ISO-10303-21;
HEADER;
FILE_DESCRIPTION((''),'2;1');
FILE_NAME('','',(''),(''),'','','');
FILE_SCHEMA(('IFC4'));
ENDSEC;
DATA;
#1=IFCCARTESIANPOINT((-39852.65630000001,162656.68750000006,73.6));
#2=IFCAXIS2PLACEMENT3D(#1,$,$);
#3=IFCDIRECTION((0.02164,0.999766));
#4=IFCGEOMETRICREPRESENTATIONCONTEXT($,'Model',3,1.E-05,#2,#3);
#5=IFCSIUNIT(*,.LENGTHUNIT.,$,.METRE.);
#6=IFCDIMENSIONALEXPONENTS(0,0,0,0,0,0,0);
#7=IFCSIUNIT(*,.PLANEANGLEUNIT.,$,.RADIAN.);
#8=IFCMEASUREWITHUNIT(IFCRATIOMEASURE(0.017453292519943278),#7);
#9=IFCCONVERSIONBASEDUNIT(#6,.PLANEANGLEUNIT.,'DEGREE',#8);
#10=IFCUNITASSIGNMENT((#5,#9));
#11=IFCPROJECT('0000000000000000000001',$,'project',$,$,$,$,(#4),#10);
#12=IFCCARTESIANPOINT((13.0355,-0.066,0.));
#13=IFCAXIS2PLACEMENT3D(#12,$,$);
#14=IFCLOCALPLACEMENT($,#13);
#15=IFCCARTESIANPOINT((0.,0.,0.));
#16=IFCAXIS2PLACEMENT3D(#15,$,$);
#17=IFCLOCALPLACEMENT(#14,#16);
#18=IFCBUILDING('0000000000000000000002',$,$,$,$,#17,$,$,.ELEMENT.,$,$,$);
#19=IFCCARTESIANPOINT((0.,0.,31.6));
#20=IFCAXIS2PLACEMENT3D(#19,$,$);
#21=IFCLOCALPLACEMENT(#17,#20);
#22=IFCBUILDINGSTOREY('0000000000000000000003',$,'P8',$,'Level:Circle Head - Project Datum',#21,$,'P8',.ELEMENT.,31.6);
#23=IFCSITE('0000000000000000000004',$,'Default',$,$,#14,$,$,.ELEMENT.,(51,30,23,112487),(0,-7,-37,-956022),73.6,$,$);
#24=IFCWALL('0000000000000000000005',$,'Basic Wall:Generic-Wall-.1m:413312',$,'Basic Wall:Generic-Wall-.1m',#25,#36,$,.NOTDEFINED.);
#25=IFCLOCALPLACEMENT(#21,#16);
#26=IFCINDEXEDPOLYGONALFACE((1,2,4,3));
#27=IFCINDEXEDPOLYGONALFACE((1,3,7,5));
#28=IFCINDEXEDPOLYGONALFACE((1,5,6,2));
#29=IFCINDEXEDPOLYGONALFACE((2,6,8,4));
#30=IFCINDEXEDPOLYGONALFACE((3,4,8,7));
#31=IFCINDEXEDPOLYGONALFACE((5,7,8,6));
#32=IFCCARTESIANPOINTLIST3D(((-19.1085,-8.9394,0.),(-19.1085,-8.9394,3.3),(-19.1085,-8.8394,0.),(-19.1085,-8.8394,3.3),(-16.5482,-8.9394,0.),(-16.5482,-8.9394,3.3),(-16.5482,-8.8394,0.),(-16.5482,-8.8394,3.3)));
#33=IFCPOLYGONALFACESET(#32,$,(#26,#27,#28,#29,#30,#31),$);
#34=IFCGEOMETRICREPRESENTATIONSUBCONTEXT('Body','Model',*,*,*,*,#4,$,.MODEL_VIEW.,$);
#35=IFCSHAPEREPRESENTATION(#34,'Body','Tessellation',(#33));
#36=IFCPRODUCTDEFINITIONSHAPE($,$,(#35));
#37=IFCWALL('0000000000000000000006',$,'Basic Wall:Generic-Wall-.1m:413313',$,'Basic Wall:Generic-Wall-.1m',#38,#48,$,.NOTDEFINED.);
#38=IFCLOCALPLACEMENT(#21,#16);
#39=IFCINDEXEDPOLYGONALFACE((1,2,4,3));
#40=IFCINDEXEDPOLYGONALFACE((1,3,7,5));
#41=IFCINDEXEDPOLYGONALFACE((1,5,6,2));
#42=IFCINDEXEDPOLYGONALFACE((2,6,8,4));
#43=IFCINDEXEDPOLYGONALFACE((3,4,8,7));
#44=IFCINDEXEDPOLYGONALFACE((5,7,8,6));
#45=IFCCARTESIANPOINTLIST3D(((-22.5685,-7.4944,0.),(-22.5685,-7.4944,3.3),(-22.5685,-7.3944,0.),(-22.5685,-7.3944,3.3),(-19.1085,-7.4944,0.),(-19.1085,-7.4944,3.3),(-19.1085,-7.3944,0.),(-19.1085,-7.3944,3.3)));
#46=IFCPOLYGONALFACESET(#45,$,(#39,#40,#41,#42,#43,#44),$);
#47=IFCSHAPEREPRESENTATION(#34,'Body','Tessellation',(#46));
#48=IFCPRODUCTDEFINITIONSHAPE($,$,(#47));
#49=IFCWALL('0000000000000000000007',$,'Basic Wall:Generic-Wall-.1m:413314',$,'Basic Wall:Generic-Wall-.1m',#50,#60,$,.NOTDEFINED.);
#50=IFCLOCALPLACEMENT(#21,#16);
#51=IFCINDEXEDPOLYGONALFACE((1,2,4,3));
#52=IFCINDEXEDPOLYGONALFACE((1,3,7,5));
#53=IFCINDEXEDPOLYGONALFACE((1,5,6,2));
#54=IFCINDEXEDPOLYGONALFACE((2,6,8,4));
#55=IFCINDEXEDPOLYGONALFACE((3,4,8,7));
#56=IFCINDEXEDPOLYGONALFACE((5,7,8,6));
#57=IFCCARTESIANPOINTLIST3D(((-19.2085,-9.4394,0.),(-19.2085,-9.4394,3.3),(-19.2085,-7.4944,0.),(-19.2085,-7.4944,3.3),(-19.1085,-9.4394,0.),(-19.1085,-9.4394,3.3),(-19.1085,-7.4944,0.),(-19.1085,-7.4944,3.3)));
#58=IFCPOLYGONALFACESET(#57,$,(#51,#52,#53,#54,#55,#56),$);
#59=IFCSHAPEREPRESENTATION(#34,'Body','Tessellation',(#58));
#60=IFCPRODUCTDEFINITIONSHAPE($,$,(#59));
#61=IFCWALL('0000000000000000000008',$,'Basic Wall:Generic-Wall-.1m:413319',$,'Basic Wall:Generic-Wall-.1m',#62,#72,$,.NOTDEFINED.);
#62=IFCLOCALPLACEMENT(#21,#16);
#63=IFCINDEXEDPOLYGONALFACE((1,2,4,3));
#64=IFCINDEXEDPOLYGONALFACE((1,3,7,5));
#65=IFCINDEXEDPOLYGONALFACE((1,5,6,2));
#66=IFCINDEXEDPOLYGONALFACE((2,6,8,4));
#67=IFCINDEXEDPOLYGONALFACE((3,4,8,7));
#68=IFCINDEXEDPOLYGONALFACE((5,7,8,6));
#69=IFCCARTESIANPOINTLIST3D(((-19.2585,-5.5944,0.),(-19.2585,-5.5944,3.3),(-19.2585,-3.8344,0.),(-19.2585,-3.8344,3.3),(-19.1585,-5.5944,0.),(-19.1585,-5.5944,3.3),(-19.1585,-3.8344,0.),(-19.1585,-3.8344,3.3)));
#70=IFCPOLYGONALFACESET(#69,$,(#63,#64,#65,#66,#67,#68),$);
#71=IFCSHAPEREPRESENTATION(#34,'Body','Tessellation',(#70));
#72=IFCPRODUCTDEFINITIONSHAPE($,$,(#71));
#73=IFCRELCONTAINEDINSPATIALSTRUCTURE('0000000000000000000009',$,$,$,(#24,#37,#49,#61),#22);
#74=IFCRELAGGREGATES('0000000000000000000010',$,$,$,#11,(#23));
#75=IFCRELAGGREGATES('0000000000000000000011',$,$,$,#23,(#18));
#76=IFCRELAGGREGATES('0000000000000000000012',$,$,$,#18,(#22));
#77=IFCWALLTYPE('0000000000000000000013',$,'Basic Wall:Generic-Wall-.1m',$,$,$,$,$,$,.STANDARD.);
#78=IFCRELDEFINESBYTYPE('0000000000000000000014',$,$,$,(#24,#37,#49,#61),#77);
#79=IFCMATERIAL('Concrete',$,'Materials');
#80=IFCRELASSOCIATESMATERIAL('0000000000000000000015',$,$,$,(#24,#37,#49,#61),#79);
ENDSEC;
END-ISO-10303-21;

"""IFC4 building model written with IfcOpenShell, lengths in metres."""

from ifc_helpers import new_model, entity, si_unit, converted_unit, direction, frame, origin, place, context, subcontext, project, spatial, indexed_curve, outline, extrude, material, type_object, element, save


model = new_model("IFC4")

# Units and contexts
model_context = context("Model", 3, precision=1e-05, world=frame((-39852.65630000001, 162656.68750000006, 73.6)), true_north=direction((0.02164, 0.999766)))
body_context = subcontext(model_context, "Body", "Model", "MODEL_VIEW")
ifc_project = project(units=[si_unit("LENGTHUNIT", "METRE"), converted_unit("PLANEANGLEUNIT", "DEGREE", entity("IfcRatioMeasure", 0.017453292519943278), si_unit("PLANEANGLEUNIT", "RADIAN"), dimensions=[0, 0, 0, 0, 0, 0, 0])], contexts=[model_context])

# Site, building, storey
site_placement = place(None, frame((13.0355, -0.066, 0.0)))
site = spatial("IfcSite", under=ifc_project, at=site_placement, Name="Default", CompositionType="ELEMENT", RefLatitude=(51, 30, 23, 112487), RefLongitude=(0, -7, -37, -956022), RefElevation=73.6)
building_placement = place(site_placement, origin())
building = spatial("IfcBuilding", under=site, at=building_placement, CompositionType="ELEMENT")
storey_placement = place(building_placement, frame((0.0, 0.0, 31.6)))
storey = spatial("IfcBuildingStorey", under=building, at=storey_placement, Name="P8", ObjectType="Level:Circle Head - Project Datum", LongName="P8", CompositionType="ELEMENT", Elevation=31.6)

# Shared definitions
ifc_material = material(Name="Concrete", Category="Materials")

# Walls
wall_type = type_object("IfcWallType", Name="Basic Wall:Generic-Wall-.1m", PredefinedType="STANDARD")
wall_1_placement = place(storey_placement, frame((-19.1085, -8.8894, 0.0)))
element("IfcWall", 1, at=wall_1_placement, inside=storey, type_object=wall_type, material=ifc_material, Name="Basic Wall:Generic-Wall-.1m:413312", ObjectType="Basic Wall:Generic-Wall-.1m", PredefinedType="NOTDEFINED", context=body_context, shape_type="SweptSolid", body=[
    extrude(outline(indexed_curve([(2.5602, 0.05), (0.0, 0.05), (0.0, -0.05), (2.5602, -0.05), (2.5602, 0.05)], self_intersect=False)), origin(), (0.0, 0.0, 1.0), 3.3),
])
wall_2_placement = place(storey_placement, frame((-22.5685, -7.4444, 0.0)))
element("IfcWall", 2, at=wall_2_placement, inside=storey, type_object=wall_type, material=ifc_material, Name="Basic Wall:Generic-Wall-.1m:413313", ObjectType="Basic Wall:Generic-Wall-.1m", PredefinedType="NOTDEFINED", context=body_context, shape_type="SweptSolid", body=[
    extrude(outline(indexed_curve([(3.46, 0.05), (0.0, 0.05), (0.0, -0.05), (3.46, -0.05), (3.46, 0.05)], self_intersect=False)), origin(), (0.0, 0.0, 1.0), 3.3),
])
wall_3_placement = place(storey_placement, frame((-19.1585, -7.4944, 0.0), z_axis=(0.0, 0.0, 1.0), x_axis=(0.0, -1.0, 0.0)))
element("IfcWall", 3, at=wall_3_placement, inside=storey, type_object=wall_type, material=ifc_material, Name="Basic Wall:Generic-Wall-.1m:413314", ObjectType="Basic Wall:Generic-Wall-.1m", PredefinedType="NOTDEFINED", context=body_context, shape_type="SweptSolid", body=[
    extrude(outline(indexed_curve([(1.945, 0.05), (0.0, 0.05), (0.0, -0.05), (1.945, -0.05), (1.945, 0.05)], self_intersect=False)), origin(), (0.0, 0.0, 1.0), 3.3),
])
wall_4_placement = place(storey_placement, frame((-19.2085, -5.5944, 0.0), z_axis=(0.0, 0.0, 1.0), x_axis=(0.0, 1.0, 0.0)))
element("IfcWall", 4, at=wall_4_placement, inside=storey, type_object=wall_type, material=ifc_material, Name="Basic Wall:Generic-Wall-.1m:413319", ObjectType="Basic Wall:Generic-Wall-.1m", PredefinedType="NOTDEFINED", context=body_context, shape_type="SweptSolid", body=[
    extrude(outline(indexed_curve([(1.76, 0.05), (0.0, 0.05), (0.0, -0.05), (1.76, -0.05), (1.76, 0.05)], self_intersect=False)), origin(), (0.0, 0.0, 1.0), 3.3),
])

save(model, "model.ifc")
